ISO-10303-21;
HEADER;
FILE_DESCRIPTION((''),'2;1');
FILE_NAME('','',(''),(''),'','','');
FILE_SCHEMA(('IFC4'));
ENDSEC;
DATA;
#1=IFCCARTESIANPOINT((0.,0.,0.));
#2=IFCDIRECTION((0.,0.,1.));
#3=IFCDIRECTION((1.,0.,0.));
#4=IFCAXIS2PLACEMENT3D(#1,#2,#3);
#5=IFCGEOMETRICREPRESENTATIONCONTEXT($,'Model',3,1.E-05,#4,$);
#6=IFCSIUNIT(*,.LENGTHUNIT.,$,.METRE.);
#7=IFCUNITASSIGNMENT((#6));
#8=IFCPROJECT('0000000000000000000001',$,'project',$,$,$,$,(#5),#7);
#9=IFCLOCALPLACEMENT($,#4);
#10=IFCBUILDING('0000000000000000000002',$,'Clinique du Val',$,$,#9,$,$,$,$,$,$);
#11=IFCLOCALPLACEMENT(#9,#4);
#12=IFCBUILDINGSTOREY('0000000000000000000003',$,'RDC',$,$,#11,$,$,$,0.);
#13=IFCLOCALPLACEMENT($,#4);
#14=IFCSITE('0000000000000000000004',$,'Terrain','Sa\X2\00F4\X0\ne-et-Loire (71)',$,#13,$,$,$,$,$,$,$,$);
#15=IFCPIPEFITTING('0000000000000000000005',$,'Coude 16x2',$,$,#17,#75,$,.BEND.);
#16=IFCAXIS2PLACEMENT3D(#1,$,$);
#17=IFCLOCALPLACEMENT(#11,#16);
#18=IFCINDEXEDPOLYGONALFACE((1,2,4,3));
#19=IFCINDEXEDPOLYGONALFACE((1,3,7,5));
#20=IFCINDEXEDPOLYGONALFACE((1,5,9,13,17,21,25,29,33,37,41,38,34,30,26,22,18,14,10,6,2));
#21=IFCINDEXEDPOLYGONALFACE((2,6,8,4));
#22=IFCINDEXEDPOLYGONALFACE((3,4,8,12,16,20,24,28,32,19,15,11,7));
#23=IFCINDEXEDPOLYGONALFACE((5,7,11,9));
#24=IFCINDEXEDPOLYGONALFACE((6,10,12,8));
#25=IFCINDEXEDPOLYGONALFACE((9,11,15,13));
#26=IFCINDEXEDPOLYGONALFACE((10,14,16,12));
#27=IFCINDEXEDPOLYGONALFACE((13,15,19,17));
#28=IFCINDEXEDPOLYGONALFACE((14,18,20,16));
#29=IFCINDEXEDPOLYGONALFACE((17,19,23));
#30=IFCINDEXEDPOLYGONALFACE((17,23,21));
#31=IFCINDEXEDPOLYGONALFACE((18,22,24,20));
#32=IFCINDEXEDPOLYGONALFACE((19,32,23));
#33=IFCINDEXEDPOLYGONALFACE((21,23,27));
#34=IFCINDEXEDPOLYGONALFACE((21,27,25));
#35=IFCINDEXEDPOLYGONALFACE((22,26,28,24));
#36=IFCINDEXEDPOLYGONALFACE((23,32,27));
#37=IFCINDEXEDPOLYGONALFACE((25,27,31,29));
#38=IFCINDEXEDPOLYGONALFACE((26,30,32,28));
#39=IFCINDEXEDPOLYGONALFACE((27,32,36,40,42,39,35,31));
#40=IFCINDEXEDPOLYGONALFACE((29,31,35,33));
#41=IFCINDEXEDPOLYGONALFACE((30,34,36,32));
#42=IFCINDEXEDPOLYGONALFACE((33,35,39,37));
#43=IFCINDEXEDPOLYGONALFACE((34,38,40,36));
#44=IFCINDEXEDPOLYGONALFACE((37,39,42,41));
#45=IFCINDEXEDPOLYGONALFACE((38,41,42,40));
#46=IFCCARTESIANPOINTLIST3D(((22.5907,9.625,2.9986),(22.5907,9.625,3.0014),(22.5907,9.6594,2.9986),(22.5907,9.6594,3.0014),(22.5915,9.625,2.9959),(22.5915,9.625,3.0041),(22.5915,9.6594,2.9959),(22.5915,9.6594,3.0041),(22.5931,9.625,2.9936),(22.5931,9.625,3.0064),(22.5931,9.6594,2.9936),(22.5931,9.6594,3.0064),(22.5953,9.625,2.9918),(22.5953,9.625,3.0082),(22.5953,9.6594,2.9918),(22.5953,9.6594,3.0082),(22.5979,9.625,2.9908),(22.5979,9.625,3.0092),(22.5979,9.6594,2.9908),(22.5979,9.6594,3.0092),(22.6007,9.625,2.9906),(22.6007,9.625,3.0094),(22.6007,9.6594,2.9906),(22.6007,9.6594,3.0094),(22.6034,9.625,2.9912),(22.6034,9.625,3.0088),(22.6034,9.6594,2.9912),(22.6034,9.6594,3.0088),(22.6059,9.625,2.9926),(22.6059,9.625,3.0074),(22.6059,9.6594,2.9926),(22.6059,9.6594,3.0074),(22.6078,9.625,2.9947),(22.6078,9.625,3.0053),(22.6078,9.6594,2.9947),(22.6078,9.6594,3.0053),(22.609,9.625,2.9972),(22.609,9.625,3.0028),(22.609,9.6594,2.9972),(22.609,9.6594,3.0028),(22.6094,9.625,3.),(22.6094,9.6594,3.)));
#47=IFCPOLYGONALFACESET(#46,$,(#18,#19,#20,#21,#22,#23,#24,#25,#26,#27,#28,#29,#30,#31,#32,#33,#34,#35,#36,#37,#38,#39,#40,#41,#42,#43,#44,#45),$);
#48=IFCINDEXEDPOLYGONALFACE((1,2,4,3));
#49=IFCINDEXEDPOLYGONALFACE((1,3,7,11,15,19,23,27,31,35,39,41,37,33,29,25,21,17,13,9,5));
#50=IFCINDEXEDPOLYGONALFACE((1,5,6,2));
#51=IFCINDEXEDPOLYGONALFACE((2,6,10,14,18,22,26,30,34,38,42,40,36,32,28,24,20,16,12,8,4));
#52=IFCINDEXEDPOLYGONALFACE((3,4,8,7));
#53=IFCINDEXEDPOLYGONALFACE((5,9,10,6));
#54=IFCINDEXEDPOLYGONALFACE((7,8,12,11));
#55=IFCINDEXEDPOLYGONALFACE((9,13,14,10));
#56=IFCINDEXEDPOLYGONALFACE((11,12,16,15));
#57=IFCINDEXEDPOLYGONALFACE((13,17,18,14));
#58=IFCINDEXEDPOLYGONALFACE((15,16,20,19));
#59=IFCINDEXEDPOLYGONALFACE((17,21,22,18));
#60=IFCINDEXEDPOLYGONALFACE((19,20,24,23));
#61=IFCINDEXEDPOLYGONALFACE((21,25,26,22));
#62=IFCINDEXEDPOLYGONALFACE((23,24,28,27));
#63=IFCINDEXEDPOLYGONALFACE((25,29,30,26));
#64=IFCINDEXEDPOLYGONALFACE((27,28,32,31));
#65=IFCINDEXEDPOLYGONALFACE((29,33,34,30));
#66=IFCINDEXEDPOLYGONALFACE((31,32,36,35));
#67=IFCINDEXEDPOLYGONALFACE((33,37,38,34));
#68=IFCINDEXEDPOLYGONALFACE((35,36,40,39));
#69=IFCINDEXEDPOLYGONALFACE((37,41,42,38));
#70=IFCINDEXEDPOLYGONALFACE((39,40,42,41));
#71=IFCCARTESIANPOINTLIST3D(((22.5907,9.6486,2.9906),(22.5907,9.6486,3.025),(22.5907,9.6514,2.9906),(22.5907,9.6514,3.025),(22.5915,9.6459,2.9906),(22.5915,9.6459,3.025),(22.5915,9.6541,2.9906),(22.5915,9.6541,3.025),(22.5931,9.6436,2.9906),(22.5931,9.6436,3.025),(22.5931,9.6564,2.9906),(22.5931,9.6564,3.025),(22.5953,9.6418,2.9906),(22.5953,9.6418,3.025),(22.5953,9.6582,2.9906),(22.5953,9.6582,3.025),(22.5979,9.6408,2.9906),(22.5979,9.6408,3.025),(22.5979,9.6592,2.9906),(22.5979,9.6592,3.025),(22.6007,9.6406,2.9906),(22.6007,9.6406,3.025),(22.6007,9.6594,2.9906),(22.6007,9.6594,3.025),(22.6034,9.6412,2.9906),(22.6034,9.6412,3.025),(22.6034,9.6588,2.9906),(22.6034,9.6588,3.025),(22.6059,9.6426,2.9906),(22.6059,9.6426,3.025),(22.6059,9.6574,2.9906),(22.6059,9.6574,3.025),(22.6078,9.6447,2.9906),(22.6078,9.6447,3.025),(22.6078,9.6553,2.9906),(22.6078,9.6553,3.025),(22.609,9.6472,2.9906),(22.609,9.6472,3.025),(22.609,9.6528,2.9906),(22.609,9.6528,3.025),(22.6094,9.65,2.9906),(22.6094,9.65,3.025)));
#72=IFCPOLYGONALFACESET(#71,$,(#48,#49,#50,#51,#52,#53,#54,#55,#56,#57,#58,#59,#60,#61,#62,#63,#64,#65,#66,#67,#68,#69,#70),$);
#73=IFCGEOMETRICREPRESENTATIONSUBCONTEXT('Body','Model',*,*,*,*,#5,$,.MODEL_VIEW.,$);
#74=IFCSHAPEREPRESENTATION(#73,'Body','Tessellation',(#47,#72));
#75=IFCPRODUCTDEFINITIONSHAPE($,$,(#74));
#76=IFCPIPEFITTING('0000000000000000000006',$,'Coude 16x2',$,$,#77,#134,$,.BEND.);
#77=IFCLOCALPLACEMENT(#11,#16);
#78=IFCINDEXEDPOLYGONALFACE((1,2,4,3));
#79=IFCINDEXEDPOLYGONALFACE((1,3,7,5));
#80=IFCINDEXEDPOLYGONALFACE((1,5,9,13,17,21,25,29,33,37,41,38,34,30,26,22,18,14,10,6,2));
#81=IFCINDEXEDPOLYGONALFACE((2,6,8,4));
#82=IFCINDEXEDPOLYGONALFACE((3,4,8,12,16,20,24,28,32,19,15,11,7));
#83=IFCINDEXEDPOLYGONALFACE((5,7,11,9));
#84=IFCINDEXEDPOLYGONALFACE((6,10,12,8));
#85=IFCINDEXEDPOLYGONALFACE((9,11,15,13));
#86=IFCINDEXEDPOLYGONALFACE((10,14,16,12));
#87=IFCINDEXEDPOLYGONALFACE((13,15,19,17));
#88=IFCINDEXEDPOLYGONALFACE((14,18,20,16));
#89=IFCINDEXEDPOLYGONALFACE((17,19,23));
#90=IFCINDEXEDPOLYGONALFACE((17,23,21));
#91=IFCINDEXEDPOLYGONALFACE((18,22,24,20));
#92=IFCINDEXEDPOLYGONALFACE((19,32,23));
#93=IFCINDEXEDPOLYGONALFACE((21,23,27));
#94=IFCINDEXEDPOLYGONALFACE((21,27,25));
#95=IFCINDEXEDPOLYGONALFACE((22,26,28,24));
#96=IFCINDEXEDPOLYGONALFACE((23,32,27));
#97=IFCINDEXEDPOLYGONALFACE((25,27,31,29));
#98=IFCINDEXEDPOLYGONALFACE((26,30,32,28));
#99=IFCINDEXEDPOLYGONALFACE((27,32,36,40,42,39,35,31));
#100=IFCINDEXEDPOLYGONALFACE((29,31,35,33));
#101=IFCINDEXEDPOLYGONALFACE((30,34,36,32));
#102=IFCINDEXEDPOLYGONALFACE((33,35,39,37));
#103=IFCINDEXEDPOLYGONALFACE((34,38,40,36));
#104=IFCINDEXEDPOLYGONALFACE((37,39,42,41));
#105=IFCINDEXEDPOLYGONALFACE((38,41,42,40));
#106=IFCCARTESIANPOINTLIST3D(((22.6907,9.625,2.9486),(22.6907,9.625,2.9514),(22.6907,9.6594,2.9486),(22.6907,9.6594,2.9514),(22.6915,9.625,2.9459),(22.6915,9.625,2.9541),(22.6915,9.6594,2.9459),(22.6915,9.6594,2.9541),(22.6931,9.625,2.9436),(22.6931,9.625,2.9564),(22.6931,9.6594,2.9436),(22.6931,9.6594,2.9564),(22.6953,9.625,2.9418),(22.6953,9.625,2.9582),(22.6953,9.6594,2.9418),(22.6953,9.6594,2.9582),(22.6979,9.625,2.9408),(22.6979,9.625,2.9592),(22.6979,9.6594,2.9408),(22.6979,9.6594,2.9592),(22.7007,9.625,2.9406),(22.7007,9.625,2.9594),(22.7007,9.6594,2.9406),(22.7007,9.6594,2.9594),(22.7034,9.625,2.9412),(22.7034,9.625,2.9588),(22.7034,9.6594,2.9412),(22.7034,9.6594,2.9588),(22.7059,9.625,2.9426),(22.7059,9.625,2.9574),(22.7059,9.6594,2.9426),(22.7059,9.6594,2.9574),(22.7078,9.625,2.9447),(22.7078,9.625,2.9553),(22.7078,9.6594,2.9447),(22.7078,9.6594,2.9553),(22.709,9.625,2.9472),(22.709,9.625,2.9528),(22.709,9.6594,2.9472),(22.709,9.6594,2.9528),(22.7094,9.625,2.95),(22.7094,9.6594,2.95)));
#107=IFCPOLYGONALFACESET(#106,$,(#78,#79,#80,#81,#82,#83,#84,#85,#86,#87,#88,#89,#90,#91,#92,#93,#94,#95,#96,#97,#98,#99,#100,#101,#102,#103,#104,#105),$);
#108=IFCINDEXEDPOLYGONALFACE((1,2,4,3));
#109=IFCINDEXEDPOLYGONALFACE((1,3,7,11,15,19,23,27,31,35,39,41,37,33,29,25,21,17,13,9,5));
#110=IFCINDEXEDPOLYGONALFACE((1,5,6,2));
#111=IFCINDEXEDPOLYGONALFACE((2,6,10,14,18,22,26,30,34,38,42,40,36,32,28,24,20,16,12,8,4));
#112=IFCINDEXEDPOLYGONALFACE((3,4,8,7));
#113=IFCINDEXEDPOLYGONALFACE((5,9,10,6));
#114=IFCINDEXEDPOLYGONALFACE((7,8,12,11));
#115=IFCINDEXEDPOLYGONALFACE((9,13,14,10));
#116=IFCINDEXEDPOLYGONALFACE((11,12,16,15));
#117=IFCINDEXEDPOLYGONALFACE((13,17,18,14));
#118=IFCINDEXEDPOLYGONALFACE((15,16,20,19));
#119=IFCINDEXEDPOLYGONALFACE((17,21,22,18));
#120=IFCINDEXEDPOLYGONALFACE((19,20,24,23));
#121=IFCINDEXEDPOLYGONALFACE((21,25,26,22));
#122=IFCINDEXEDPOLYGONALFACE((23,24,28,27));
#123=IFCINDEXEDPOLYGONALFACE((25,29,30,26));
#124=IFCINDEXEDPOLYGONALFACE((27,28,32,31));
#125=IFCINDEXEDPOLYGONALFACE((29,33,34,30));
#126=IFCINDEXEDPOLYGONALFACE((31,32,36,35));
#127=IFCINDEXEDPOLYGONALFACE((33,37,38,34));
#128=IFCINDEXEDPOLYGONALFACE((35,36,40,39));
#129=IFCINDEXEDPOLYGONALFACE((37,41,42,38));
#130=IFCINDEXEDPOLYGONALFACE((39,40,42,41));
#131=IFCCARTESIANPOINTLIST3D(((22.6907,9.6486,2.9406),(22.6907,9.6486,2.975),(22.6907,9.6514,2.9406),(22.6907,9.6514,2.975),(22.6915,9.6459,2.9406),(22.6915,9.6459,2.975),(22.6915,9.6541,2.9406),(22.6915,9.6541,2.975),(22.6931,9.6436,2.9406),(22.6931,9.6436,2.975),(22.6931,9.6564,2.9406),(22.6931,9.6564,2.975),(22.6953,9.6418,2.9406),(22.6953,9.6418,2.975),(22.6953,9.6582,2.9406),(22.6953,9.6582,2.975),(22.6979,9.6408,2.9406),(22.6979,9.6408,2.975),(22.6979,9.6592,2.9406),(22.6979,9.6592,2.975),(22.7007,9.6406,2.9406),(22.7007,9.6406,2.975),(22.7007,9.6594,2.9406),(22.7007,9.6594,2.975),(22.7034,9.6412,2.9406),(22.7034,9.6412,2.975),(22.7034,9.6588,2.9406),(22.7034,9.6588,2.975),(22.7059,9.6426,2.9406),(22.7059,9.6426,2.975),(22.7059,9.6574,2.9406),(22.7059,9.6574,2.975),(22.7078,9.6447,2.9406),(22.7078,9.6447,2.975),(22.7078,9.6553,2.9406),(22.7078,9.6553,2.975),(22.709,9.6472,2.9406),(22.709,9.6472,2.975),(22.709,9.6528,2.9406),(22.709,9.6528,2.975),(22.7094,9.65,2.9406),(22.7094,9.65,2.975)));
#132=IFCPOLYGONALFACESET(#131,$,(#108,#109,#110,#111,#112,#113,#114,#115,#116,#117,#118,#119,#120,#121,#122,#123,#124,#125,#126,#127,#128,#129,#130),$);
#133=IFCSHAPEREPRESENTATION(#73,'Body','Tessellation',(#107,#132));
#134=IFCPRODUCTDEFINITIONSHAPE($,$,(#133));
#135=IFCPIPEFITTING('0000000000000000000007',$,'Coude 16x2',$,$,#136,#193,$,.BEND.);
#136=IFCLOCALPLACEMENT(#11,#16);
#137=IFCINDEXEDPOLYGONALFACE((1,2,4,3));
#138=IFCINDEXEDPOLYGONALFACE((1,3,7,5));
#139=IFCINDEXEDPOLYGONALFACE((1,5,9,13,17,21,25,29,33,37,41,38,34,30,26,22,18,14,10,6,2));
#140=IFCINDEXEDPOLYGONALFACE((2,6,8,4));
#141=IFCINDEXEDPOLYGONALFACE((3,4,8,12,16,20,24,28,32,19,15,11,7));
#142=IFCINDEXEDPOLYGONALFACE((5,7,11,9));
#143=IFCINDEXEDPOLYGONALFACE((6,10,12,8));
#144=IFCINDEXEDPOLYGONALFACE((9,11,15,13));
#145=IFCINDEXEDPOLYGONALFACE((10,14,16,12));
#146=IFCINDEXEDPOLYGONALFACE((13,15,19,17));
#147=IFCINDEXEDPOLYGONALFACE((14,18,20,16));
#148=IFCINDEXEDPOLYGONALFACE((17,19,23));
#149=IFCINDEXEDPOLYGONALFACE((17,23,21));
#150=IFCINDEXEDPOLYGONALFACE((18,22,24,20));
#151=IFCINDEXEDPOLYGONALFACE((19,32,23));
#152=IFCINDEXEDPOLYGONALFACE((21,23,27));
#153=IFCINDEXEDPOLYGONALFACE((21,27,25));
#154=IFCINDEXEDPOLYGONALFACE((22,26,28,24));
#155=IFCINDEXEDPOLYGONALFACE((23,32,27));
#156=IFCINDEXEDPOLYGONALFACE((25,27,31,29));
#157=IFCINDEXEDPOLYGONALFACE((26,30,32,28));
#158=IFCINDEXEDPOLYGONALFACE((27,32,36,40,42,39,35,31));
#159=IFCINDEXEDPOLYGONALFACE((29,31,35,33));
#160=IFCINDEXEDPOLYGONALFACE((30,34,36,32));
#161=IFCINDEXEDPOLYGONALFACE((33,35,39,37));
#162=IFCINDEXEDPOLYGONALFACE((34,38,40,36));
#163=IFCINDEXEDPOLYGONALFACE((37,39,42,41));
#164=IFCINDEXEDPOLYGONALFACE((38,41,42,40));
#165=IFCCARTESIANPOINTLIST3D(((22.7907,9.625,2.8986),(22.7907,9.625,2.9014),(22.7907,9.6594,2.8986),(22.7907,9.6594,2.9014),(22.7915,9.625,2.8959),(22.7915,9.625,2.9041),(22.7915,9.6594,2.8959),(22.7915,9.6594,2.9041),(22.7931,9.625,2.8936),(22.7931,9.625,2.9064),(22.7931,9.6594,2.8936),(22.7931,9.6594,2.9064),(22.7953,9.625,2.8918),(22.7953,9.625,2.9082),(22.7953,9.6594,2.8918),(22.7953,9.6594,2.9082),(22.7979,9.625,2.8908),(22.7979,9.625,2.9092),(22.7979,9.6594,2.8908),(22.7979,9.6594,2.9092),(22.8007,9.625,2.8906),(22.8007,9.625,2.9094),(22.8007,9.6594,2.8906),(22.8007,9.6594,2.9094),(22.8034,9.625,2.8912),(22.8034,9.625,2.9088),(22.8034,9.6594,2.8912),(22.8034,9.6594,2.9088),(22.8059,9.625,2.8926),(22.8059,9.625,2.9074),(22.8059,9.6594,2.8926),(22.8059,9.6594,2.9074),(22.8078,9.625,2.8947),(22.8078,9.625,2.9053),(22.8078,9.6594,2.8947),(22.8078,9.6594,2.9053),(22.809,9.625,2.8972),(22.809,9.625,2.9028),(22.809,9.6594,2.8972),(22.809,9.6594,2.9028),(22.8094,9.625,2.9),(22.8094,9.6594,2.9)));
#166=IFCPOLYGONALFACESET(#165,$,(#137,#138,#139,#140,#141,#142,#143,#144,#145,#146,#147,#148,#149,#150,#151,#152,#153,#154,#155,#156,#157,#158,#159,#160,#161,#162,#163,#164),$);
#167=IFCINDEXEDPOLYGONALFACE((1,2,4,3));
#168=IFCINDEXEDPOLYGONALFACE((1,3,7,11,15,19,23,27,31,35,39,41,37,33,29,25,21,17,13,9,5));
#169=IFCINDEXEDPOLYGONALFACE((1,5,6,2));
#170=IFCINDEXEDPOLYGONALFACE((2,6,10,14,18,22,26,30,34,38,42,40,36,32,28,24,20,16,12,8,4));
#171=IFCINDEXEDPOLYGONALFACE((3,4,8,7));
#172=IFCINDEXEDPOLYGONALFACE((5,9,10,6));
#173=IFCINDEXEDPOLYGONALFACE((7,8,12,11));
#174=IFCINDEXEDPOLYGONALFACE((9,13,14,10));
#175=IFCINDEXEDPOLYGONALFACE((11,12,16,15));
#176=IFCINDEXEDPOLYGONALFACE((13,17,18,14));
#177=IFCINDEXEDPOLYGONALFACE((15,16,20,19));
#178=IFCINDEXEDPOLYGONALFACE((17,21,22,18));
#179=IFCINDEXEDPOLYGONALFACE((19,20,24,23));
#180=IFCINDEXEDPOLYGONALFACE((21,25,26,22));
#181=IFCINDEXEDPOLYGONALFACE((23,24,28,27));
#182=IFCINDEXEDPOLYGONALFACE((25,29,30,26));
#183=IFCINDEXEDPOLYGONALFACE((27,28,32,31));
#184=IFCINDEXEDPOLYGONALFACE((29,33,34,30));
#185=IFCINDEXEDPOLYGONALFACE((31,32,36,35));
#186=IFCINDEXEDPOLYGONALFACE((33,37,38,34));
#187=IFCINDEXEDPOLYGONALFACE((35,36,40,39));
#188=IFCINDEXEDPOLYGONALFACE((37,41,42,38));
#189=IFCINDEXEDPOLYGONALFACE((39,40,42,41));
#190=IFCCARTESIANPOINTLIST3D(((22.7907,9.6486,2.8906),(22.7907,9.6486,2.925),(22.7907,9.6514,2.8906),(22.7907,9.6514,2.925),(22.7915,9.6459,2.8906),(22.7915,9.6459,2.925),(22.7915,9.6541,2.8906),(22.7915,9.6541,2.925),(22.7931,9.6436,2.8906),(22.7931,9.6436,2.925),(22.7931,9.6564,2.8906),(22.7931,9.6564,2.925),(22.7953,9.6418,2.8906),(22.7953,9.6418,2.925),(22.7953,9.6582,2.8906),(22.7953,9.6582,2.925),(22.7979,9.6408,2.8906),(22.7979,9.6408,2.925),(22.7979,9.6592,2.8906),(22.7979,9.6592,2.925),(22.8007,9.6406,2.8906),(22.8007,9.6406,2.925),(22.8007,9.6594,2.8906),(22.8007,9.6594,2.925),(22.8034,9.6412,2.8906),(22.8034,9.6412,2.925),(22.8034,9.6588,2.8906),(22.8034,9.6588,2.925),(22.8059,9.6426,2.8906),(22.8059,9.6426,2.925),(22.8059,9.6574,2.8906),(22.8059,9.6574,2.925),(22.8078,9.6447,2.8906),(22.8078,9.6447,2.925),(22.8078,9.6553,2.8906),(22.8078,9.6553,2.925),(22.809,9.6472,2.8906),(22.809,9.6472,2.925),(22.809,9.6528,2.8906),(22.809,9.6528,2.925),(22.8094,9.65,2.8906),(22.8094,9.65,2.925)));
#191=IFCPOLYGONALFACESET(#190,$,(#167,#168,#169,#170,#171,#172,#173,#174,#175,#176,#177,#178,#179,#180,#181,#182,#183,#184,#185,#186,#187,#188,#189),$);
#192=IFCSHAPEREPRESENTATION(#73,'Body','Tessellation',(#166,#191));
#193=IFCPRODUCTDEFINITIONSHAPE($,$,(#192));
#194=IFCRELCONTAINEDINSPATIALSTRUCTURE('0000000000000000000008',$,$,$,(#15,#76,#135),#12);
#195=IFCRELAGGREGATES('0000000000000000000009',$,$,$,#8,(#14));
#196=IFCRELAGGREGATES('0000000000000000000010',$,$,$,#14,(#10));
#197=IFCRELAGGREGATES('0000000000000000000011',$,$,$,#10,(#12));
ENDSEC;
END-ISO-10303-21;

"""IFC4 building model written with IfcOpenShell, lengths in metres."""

from ifc_helpers import new_model, si_unit, frame, origin_with_axes, place, context, subcontext, project, spatial, circle, extrude, element, save


model = new_model("IFC4")

# Units and contexts
model_context = context("Model", 3, precision=1e-05, world=origin_with_axes())
body_context = subcontext(model_context, "Body", "Model", "MODEL_VIEW")
ifc_project = project(units=[si_unit("LENGTHUNIT", "METRE")], contexts=[model_context])

# Site, building, storey
site_placement = place(None, origin_with_axes())
site = spatial("IfcSite", under=ifc_project, at=site_placement, Name="Terrain", Description="Saône-et-Loire (71)")
building_placement = place(None, origin_with_axes())
building = spatial("IfcBuilding", under=site, at=building_placement, Name="Clinique du Val")
storey_placement = place(building_placement, origin_with_axes())
storey = spatial("IfcBuildingStorey", under=building, at=storey_placement, Name="RDC", Elevation=0.0)

# Pipe fittings
for number, where, z_axis, x_axis, name in (
    (1, (22.6, 9.65, 3.0), (0.0, 0.0, 1.0), (1.0, 0.0, 0.0), "Coude 16x2"),
    (2, (22.7, 9.65, 2.95), (0.0, 0.0, 1.0), (1.0, 0.0, 0.0), "Coude 16x2"),
    (3, (22.8, 9.65, 2.9), (0.0, 0.0, 1.0), (1.0, 0.0, 0.0), "Coude 16x2"),
):
    element("IfcPipeFitting", number, at=place(storey_placement, frame(where, z_axis=z_axis, x_axis=x_axis)), inside=storey, Name=name, PredefinedType="BEND", context=body_context, shape_type="SweptSolid", body=[
        extrude(circle(Radius=0.0094), frame((0.0, 0.0094, 0.0), z_axis=(0.0, -1.0, 0.0), x_axis=(1.0, 0.0, 0.0)), (0.0, 0.0, 1.0), 0.0344),
        extrude(circle(Radius=0.0094), frame((0.0, 0.0, -0.0094), z_axis=(0.0, 0.0, 1.0), x_axis=(1.0, 0.0, 0.0)), (0.0, 0.0, 1.0), 0.0344),
    ])

save(model, "model.ifc")
